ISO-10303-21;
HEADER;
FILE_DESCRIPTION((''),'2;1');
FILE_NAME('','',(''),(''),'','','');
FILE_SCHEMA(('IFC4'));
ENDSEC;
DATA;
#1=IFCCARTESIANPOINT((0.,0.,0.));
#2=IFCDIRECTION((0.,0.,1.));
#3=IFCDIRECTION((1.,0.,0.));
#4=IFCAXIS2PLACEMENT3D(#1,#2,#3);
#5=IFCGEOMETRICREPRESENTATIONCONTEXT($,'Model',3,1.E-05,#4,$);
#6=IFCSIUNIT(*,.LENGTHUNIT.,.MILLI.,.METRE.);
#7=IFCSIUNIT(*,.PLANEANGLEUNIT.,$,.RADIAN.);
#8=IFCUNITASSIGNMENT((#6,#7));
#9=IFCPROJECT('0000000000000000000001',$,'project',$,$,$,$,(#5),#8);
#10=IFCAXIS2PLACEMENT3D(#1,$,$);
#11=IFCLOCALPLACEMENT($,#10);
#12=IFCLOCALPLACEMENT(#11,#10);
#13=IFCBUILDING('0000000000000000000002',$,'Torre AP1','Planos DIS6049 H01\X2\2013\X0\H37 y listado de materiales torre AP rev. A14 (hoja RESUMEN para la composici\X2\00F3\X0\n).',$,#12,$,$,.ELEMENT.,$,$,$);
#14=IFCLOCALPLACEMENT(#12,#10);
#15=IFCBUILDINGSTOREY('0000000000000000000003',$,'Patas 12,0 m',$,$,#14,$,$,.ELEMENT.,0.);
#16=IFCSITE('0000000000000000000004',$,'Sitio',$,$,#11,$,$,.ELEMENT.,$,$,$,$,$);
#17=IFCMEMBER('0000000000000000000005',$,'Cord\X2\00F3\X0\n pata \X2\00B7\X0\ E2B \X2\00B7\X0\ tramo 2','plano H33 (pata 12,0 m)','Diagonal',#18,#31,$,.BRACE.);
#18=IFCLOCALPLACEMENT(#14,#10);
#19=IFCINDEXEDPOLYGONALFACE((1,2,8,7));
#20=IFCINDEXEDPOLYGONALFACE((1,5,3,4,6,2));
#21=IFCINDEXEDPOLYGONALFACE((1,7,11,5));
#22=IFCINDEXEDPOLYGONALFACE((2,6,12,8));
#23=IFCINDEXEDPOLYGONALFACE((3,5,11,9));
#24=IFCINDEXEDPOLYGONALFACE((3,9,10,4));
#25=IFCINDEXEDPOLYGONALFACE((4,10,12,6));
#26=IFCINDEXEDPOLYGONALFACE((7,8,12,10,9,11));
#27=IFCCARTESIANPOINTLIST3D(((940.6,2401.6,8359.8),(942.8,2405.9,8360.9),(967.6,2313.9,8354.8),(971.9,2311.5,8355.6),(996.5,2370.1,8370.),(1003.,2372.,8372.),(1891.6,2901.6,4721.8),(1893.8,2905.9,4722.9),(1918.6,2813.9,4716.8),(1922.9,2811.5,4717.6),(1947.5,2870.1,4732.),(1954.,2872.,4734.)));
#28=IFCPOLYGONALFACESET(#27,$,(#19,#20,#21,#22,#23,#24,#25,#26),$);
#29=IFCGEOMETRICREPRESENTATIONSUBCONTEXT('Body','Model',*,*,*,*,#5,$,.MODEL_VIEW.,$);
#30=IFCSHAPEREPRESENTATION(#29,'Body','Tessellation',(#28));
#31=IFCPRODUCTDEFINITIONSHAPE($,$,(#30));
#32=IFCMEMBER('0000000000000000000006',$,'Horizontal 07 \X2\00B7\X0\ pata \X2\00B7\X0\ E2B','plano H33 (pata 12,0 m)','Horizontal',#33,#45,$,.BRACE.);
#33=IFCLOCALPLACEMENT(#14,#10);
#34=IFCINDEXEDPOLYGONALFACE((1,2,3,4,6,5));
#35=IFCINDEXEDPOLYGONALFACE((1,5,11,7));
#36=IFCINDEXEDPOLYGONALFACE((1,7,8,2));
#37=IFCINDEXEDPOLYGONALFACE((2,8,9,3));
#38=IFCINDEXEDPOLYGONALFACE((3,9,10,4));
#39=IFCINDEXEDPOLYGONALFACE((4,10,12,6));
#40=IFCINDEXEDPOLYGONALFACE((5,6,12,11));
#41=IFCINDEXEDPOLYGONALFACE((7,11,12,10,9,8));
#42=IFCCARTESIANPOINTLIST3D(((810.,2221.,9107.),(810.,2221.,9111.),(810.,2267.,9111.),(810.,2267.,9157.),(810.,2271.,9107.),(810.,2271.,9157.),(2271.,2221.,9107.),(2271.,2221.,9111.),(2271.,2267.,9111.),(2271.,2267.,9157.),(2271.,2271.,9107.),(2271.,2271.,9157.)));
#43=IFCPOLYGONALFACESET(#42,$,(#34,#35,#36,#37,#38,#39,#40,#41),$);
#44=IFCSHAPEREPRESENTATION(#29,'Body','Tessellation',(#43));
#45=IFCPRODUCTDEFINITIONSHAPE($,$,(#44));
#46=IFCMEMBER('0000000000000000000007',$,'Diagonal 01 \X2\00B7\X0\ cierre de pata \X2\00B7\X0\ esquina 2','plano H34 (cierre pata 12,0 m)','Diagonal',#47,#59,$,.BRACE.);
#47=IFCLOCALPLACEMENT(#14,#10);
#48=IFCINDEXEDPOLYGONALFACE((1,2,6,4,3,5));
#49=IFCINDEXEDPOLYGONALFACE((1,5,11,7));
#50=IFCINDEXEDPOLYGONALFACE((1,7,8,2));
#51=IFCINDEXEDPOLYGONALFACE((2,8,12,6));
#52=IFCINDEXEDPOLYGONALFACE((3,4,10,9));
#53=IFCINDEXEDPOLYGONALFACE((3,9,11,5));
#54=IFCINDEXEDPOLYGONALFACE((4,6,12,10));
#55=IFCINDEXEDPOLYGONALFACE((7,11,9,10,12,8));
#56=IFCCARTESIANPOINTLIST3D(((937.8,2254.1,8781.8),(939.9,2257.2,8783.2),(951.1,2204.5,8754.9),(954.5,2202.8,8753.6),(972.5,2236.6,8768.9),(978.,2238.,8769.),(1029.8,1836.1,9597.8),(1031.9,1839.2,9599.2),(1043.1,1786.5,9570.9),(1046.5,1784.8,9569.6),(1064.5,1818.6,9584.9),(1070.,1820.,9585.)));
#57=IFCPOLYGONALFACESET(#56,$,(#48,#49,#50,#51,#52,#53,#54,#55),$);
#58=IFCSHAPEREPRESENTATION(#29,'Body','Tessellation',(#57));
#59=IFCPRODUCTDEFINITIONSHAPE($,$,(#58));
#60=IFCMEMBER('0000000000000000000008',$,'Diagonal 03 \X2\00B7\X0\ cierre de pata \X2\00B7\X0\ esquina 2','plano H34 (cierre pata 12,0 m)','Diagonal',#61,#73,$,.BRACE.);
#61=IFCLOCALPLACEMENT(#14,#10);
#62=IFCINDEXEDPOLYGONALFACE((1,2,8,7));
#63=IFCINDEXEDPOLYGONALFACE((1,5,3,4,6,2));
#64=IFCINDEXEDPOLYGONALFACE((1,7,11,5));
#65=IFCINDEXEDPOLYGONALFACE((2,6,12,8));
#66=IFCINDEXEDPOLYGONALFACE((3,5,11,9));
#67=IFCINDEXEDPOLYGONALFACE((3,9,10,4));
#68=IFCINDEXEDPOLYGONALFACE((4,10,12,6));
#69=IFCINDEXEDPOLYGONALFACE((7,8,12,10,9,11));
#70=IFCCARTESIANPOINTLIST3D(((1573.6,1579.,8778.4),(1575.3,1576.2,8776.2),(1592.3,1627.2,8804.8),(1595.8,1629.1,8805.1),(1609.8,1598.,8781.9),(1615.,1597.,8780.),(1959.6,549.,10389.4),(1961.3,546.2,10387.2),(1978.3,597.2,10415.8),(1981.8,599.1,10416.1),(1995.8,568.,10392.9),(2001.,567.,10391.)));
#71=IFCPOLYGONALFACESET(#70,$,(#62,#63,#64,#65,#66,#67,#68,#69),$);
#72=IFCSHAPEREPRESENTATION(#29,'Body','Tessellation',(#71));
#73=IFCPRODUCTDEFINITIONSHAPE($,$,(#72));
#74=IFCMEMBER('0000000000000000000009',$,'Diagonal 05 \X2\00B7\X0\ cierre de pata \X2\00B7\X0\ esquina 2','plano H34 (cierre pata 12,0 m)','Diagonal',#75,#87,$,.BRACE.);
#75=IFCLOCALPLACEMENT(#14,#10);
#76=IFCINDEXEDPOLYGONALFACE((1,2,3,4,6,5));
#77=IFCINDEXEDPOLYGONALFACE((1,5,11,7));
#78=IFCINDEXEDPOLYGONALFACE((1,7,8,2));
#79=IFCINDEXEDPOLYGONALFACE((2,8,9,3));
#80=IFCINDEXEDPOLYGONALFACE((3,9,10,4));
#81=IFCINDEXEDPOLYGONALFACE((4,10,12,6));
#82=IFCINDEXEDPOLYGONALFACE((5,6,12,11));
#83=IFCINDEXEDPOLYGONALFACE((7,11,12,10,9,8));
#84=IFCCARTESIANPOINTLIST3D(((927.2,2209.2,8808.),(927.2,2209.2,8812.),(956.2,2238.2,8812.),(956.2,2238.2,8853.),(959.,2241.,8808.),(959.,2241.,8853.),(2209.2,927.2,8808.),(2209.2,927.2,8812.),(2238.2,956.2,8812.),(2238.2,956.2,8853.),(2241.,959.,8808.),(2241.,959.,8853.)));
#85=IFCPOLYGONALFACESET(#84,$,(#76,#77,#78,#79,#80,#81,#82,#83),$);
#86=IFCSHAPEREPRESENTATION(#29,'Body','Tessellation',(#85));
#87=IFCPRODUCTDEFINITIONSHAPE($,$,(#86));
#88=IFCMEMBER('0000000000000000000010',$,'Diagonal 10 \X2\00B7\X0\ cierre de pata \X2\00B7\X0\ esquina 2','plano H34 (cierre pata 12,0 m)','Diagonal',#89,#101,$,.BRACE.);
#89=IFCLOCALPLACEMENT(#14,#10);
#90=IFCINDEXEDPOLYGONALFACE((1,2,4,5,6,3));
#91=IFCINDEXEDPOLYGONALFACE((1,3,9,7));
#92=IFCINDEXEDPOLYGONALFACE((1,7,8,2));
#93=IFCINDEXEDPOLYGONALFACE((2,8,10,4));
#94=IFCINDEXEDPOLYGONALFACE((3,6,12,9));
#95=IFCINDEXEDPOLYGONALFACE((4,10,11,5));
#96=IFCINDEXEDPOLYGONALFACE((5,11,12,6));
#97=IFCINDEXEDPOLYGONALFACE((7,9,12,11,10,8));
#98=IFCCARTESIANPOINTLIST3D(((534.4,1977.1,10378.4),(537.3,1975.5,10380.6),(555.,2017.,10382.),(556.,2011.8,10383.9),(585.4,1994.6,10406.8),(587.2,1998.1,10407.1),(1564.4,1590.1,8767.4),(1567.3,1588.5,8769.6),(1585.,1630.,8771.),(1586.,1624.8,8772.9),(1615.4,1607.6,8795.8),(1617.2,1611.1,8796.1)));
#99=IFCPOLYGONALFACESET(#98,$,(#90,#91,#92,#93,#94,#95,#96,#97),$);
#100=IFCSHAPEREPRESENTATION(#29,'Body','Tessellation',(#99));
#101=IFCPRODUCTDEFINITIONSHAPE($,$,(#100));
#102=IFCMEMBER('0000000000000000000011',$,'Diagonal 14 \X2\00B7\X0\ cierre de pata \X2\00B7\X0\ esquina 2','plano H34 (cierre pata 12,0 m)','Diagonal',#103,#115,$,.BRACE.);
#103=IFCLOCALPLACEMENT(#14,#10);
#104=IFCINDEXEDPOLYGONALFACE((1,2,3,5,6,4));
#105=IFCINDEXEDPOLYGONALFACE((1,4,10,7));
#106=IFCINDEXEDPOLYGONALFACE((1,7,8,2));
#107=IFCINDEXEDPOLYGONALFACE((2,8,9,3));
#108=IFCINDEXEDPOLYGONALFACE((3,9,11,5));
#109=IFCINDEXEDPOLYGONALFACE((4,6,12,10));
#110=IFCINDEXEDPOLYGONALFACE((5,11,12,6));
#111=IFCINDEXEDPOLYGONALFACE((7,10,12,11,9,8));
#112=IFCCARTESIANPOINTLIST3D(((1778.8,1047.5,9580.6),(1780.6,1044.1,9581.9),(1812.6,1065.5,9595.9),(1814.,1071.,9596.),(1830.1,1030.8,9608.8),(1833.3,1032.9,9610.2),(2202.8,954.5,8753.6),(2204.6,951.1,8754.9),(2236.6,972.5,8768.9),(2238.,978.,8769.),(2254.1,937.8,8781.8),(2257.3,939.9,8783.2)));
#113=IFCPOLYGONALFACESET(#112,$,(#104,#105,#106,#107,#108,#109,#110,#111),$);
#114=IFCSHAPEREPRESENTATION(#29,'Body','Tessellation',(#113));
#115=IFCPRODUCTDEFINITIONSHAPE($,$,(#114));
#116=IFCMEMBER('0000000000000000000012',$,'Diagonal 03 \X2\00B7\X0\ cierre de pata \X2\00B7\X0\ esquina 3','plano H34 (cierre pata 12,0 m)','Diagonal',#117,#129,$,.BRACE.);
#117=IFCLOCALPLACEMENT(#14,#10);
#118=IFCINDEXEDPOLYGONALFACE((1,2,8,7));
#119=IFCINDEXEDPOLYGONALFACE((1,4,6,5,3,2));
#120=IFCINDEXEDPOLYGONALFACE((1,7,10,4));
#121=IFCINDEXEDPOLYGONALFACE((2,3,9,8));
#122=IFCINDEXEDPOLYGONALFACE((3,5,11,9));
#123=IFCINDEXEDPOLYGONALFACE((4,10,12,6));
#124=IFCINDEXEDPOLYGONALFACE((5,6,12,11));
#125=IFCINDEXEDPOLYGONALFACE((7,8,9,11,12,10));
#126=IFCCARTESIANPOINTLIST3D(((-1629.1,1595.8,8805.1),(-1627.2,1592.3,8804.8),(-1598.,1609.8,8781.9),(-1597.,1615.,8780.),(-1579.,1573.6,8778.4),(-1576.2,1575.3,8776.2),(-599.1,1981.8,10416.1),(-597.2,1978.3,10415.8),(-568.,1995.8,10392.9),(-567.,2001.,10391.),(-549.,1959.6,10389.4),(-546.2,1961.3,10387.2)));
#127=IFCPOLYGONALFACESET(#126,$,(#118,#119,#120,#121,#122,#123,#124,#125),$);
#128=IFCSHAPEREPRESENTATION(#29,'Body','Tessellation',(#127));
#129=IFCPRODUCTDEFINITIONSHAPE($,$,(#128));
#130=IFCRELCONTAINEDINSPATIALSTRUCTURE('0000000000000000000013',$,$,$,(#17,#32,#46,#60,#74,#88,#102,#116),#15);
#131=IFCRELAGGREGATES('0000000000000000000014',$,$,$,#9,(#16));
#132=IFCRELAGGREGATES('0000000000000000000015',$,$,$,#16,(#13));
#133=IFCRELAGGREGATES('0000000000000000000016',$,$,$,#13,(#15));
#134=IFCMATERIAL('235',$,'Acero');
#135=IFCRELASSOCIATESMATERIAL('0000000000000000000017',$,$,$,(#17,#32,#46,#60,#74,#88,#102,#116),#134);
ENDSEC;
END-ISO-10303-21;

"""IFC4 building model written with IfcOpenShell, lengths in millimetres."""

from ifc_helpers import new_model, si_unit, frame, frame_2d, origin, origin_with_axes, place, context, subcontext, project, spatial, l_section, extrude, material, element, save


model = new_model("IFC4")

# Units and contexts
model_context = context("Model", 3, precision=1e-05, world=origin_with_axes())
body_context = subcontext(model_context, "Body", "Model", "MODEL_VIEW")
ifc_project = project(units=[si_unit("LENGTHUNIT", "METRE", prefix="MILLI"), si_unit("PLANEANGLEUNIT", "RADIAN")], contexts=[model_context])

# Site, building, storey
site_placement = place(None, origin())
site = spatial("IfcSite", under=ifc_project, at=site_placement, Name="Sitio", CompositionType="ELEMENT")
building_placement = place(site_placement, origin())
building = spatial("IfcBuilding", under=site, at=building_placement, Name="Torre AP1", Description="Planos DIS6049 H01–H37 y listado de materiales torre AP rev. A14 (hoja RESUMEN para la composición).", CompositionType="ELEMENT")
storey_placement = place(building_placement, origin())
storey = spatial("IfcBuildingStorey", under=building, at=storey_placement, Name="Patas 12,0 m", CompositionType="ELEMENT", Elevation=0.0)

# Members
ifc_material_1 = material(Name="235", Category="Acero")
member_1_placement = place(storey_placement, frame((1003.0, 2372.0, 8372.0), z_axis=(0.250702, 0.13181, -0.959049), x_axis=(-0.444282, -0.864528, -0.234958)))
element("IfcMember", 1, at=member_1_placement, inside=storey, material=ifc_material_1, Name="Cordón pata · E2B · tramo 2", Description="plano H33 (pata 12,0 m)", ObjectType="Diagonal", PredefinedType="BRACE", context=body_context, shape_type="SweptSolid", body=[
    extrude(l_section(Depth=70.0, Width=70.0, Thickness=5.0, at=frame_2d((35.0, 35.0))), None, (0.0, 0.0, 1.0), 3793.3),
])
member_2_placement = place(storey_placement, frame((2271.0, 2271.0, 9107.0), z_axis=(-1.0, 0.0, 0.0), x_axis=(0.0, -1.0, 0.0)))
element("IfcMember", 2, at=member_2_placement, inside=storey, material=ifc_material_1, Name="Horizontal 07 · pata · E2B", Description="plano H33 (pata 12,0 m)", ObjectType="Horizontal", PredefinedType="BRACE", context=body_context, shape_type="SweptSolid", body=[
    extrude(l_section(Depth=50.0, Width=50.0, Thickness=4.0, at=frame_2d((25.0, 25.0))), None, (0.0, 0.0, 1.0), 1461.0),
])
member_3_placement = place(storey_placement, frame((1070.0, 1820.0, 9585.0), z_axis=(-0.099844, 0.45364, -0.885574), x_axis=(-0.521462, -0.78186, -0.34172)))
element("IfcMember", 3, at=member_3_placement, inside=storey, material=ifc_material_1, Name="Diagonal 01 · cierre de pata · esquina 2", Description="plano H34 (cierre pata 12,0 m)", ObjectType="Diagonal", PredefinedType="BRACE", context=body_context, shape_type="SweptSolid", body=[
    extrude(l_section(Depth=45.0, Width=45.0, Thickness=4.0, at=frame_2d((22.5, 22.5))), None, (0.0, 0.0, 1.0), 921.4),
])
member_4_placement = place(storey_placement, frame((2001.0, 567.0, 10391.0), z_axis=(-0.197878, 0.528017, -0.825859), x_axis=(-0.882679, -0.462384, -0.084135)))
element("IfcMember", 4, at=member_4_placement, inside=storey, material=ifc_material_1, Name="Diagonal 03 · cierre de pata · esquina 2", Description="plano H34 (cierre pata 12,0 m)", ObjectType="Diagonal", PredefinedType="BRACE", context=body_context, shape_type="SweptSolid", body=[
    extrude(l_section(Depth=45.0, Width=45.0, Thickness=4.0, at=frame_2d((22.5, 22.5))), None, (0.0, 0.0, 1.0), 1950.7),
])
member_5_placement = place(storey_placement, frame((2241.0, 959.0, 8808.0), z_axis=(-0.707107, 0.707107, 0.0), x_axis=(-0.707107, -0.707107, 0.0)))
element("IfcMember", 5, at=member_5_placement, inside=storey, material=ifc_material_1, Name="Diagonal 05 · cierre de pata · esquina 2", Description="plano H34 (cierre pata 12,0 m)", ObjectType="Diagonal", PredefinedType="BRACE", context=body_context, shape_type="SweptSolid", body=[
    extrude(l_section(Depth=45.0, Width=45.0, Thickness=4.0, at=frame_2d((22.5, 22.5))), None, (0.0, 0.0, 1.0), 1813.0),
])
member_6_placement = place(storey_placement, frame((1585.0, 1630.0, 8771.0), z_axis=(-0.527963, 0.198371, 0.825775), x_axis=(-0.457467, -0.885645, -0.079731)))
element("IfcMember", 6, at=member_6_placement, inside=storey, material=ifc_material_1, Name="Diagonal 10 · cierre de pata · esquina 2", Description="plano H34 (cierre pata 12,0 m)", ObjectType="Diagonal", PredefinedType="BRACE", context=body_context, shape_type="SweptSolid", body=[
    extrude(l_section(Depth=45.0, Width=45.0, Thickness=4.0, at=frame_2d((22.5, 22.5))), None, (0.0, 0.0, 1.0), 1950.9),
])
member_7_placement = place(storey_placement, frame((2238.0, 978.0, 8769.0), z_axis=(-0.453962, 0.099572, 0.88544), x_axis=(-0.781324, -0.522172, -0.341862)))
element("IfcMember", 7, at=member_7_placement, inside=storey, material=ifc_material_1, Name="Diagonal 14 · cierre de pata · esquina 2", Description="plano H34 (cierre pata 12,0 m)", ObjectType="Diagonal", PredefinedType="BRACE", context=body_context, shape_type="SweptSolid", body=[
    extrude(l_section(Depth=45.0, Width=45.0, Thickness=4.0, at=frame_2d((22.5, 22.5))), None, (0.0, 0.0, 1.0), 934.0),
])
member_8_placement = place(storey_placement, frame((-567.0, 2001.0, 10391.0), z_axis=(-0.528017, -0.197878, -0.825859), x_axis=(0.462384, -0.882679, -0.084135)))
element("IfcMember", 8, at=member_8_placement, inside=storey, material=ifc_material_1, Name="Diagonal 03 · cierre de pata · esquina 3", Description="plano H34 (cierre pata 12,0 m)", ObjectType="Diagonal", PredefinedType="BRACE", context=body_context, shape_type="SweptSolid", body=[
    extrude(l_section(Depth=45.0, Width=45.0, Thickness=4.0, at=frame_2d((22.5, 22.5))), None, (0.0, 0.0, 1.0), 1950.7),
])

save(model, "model.ifc")
